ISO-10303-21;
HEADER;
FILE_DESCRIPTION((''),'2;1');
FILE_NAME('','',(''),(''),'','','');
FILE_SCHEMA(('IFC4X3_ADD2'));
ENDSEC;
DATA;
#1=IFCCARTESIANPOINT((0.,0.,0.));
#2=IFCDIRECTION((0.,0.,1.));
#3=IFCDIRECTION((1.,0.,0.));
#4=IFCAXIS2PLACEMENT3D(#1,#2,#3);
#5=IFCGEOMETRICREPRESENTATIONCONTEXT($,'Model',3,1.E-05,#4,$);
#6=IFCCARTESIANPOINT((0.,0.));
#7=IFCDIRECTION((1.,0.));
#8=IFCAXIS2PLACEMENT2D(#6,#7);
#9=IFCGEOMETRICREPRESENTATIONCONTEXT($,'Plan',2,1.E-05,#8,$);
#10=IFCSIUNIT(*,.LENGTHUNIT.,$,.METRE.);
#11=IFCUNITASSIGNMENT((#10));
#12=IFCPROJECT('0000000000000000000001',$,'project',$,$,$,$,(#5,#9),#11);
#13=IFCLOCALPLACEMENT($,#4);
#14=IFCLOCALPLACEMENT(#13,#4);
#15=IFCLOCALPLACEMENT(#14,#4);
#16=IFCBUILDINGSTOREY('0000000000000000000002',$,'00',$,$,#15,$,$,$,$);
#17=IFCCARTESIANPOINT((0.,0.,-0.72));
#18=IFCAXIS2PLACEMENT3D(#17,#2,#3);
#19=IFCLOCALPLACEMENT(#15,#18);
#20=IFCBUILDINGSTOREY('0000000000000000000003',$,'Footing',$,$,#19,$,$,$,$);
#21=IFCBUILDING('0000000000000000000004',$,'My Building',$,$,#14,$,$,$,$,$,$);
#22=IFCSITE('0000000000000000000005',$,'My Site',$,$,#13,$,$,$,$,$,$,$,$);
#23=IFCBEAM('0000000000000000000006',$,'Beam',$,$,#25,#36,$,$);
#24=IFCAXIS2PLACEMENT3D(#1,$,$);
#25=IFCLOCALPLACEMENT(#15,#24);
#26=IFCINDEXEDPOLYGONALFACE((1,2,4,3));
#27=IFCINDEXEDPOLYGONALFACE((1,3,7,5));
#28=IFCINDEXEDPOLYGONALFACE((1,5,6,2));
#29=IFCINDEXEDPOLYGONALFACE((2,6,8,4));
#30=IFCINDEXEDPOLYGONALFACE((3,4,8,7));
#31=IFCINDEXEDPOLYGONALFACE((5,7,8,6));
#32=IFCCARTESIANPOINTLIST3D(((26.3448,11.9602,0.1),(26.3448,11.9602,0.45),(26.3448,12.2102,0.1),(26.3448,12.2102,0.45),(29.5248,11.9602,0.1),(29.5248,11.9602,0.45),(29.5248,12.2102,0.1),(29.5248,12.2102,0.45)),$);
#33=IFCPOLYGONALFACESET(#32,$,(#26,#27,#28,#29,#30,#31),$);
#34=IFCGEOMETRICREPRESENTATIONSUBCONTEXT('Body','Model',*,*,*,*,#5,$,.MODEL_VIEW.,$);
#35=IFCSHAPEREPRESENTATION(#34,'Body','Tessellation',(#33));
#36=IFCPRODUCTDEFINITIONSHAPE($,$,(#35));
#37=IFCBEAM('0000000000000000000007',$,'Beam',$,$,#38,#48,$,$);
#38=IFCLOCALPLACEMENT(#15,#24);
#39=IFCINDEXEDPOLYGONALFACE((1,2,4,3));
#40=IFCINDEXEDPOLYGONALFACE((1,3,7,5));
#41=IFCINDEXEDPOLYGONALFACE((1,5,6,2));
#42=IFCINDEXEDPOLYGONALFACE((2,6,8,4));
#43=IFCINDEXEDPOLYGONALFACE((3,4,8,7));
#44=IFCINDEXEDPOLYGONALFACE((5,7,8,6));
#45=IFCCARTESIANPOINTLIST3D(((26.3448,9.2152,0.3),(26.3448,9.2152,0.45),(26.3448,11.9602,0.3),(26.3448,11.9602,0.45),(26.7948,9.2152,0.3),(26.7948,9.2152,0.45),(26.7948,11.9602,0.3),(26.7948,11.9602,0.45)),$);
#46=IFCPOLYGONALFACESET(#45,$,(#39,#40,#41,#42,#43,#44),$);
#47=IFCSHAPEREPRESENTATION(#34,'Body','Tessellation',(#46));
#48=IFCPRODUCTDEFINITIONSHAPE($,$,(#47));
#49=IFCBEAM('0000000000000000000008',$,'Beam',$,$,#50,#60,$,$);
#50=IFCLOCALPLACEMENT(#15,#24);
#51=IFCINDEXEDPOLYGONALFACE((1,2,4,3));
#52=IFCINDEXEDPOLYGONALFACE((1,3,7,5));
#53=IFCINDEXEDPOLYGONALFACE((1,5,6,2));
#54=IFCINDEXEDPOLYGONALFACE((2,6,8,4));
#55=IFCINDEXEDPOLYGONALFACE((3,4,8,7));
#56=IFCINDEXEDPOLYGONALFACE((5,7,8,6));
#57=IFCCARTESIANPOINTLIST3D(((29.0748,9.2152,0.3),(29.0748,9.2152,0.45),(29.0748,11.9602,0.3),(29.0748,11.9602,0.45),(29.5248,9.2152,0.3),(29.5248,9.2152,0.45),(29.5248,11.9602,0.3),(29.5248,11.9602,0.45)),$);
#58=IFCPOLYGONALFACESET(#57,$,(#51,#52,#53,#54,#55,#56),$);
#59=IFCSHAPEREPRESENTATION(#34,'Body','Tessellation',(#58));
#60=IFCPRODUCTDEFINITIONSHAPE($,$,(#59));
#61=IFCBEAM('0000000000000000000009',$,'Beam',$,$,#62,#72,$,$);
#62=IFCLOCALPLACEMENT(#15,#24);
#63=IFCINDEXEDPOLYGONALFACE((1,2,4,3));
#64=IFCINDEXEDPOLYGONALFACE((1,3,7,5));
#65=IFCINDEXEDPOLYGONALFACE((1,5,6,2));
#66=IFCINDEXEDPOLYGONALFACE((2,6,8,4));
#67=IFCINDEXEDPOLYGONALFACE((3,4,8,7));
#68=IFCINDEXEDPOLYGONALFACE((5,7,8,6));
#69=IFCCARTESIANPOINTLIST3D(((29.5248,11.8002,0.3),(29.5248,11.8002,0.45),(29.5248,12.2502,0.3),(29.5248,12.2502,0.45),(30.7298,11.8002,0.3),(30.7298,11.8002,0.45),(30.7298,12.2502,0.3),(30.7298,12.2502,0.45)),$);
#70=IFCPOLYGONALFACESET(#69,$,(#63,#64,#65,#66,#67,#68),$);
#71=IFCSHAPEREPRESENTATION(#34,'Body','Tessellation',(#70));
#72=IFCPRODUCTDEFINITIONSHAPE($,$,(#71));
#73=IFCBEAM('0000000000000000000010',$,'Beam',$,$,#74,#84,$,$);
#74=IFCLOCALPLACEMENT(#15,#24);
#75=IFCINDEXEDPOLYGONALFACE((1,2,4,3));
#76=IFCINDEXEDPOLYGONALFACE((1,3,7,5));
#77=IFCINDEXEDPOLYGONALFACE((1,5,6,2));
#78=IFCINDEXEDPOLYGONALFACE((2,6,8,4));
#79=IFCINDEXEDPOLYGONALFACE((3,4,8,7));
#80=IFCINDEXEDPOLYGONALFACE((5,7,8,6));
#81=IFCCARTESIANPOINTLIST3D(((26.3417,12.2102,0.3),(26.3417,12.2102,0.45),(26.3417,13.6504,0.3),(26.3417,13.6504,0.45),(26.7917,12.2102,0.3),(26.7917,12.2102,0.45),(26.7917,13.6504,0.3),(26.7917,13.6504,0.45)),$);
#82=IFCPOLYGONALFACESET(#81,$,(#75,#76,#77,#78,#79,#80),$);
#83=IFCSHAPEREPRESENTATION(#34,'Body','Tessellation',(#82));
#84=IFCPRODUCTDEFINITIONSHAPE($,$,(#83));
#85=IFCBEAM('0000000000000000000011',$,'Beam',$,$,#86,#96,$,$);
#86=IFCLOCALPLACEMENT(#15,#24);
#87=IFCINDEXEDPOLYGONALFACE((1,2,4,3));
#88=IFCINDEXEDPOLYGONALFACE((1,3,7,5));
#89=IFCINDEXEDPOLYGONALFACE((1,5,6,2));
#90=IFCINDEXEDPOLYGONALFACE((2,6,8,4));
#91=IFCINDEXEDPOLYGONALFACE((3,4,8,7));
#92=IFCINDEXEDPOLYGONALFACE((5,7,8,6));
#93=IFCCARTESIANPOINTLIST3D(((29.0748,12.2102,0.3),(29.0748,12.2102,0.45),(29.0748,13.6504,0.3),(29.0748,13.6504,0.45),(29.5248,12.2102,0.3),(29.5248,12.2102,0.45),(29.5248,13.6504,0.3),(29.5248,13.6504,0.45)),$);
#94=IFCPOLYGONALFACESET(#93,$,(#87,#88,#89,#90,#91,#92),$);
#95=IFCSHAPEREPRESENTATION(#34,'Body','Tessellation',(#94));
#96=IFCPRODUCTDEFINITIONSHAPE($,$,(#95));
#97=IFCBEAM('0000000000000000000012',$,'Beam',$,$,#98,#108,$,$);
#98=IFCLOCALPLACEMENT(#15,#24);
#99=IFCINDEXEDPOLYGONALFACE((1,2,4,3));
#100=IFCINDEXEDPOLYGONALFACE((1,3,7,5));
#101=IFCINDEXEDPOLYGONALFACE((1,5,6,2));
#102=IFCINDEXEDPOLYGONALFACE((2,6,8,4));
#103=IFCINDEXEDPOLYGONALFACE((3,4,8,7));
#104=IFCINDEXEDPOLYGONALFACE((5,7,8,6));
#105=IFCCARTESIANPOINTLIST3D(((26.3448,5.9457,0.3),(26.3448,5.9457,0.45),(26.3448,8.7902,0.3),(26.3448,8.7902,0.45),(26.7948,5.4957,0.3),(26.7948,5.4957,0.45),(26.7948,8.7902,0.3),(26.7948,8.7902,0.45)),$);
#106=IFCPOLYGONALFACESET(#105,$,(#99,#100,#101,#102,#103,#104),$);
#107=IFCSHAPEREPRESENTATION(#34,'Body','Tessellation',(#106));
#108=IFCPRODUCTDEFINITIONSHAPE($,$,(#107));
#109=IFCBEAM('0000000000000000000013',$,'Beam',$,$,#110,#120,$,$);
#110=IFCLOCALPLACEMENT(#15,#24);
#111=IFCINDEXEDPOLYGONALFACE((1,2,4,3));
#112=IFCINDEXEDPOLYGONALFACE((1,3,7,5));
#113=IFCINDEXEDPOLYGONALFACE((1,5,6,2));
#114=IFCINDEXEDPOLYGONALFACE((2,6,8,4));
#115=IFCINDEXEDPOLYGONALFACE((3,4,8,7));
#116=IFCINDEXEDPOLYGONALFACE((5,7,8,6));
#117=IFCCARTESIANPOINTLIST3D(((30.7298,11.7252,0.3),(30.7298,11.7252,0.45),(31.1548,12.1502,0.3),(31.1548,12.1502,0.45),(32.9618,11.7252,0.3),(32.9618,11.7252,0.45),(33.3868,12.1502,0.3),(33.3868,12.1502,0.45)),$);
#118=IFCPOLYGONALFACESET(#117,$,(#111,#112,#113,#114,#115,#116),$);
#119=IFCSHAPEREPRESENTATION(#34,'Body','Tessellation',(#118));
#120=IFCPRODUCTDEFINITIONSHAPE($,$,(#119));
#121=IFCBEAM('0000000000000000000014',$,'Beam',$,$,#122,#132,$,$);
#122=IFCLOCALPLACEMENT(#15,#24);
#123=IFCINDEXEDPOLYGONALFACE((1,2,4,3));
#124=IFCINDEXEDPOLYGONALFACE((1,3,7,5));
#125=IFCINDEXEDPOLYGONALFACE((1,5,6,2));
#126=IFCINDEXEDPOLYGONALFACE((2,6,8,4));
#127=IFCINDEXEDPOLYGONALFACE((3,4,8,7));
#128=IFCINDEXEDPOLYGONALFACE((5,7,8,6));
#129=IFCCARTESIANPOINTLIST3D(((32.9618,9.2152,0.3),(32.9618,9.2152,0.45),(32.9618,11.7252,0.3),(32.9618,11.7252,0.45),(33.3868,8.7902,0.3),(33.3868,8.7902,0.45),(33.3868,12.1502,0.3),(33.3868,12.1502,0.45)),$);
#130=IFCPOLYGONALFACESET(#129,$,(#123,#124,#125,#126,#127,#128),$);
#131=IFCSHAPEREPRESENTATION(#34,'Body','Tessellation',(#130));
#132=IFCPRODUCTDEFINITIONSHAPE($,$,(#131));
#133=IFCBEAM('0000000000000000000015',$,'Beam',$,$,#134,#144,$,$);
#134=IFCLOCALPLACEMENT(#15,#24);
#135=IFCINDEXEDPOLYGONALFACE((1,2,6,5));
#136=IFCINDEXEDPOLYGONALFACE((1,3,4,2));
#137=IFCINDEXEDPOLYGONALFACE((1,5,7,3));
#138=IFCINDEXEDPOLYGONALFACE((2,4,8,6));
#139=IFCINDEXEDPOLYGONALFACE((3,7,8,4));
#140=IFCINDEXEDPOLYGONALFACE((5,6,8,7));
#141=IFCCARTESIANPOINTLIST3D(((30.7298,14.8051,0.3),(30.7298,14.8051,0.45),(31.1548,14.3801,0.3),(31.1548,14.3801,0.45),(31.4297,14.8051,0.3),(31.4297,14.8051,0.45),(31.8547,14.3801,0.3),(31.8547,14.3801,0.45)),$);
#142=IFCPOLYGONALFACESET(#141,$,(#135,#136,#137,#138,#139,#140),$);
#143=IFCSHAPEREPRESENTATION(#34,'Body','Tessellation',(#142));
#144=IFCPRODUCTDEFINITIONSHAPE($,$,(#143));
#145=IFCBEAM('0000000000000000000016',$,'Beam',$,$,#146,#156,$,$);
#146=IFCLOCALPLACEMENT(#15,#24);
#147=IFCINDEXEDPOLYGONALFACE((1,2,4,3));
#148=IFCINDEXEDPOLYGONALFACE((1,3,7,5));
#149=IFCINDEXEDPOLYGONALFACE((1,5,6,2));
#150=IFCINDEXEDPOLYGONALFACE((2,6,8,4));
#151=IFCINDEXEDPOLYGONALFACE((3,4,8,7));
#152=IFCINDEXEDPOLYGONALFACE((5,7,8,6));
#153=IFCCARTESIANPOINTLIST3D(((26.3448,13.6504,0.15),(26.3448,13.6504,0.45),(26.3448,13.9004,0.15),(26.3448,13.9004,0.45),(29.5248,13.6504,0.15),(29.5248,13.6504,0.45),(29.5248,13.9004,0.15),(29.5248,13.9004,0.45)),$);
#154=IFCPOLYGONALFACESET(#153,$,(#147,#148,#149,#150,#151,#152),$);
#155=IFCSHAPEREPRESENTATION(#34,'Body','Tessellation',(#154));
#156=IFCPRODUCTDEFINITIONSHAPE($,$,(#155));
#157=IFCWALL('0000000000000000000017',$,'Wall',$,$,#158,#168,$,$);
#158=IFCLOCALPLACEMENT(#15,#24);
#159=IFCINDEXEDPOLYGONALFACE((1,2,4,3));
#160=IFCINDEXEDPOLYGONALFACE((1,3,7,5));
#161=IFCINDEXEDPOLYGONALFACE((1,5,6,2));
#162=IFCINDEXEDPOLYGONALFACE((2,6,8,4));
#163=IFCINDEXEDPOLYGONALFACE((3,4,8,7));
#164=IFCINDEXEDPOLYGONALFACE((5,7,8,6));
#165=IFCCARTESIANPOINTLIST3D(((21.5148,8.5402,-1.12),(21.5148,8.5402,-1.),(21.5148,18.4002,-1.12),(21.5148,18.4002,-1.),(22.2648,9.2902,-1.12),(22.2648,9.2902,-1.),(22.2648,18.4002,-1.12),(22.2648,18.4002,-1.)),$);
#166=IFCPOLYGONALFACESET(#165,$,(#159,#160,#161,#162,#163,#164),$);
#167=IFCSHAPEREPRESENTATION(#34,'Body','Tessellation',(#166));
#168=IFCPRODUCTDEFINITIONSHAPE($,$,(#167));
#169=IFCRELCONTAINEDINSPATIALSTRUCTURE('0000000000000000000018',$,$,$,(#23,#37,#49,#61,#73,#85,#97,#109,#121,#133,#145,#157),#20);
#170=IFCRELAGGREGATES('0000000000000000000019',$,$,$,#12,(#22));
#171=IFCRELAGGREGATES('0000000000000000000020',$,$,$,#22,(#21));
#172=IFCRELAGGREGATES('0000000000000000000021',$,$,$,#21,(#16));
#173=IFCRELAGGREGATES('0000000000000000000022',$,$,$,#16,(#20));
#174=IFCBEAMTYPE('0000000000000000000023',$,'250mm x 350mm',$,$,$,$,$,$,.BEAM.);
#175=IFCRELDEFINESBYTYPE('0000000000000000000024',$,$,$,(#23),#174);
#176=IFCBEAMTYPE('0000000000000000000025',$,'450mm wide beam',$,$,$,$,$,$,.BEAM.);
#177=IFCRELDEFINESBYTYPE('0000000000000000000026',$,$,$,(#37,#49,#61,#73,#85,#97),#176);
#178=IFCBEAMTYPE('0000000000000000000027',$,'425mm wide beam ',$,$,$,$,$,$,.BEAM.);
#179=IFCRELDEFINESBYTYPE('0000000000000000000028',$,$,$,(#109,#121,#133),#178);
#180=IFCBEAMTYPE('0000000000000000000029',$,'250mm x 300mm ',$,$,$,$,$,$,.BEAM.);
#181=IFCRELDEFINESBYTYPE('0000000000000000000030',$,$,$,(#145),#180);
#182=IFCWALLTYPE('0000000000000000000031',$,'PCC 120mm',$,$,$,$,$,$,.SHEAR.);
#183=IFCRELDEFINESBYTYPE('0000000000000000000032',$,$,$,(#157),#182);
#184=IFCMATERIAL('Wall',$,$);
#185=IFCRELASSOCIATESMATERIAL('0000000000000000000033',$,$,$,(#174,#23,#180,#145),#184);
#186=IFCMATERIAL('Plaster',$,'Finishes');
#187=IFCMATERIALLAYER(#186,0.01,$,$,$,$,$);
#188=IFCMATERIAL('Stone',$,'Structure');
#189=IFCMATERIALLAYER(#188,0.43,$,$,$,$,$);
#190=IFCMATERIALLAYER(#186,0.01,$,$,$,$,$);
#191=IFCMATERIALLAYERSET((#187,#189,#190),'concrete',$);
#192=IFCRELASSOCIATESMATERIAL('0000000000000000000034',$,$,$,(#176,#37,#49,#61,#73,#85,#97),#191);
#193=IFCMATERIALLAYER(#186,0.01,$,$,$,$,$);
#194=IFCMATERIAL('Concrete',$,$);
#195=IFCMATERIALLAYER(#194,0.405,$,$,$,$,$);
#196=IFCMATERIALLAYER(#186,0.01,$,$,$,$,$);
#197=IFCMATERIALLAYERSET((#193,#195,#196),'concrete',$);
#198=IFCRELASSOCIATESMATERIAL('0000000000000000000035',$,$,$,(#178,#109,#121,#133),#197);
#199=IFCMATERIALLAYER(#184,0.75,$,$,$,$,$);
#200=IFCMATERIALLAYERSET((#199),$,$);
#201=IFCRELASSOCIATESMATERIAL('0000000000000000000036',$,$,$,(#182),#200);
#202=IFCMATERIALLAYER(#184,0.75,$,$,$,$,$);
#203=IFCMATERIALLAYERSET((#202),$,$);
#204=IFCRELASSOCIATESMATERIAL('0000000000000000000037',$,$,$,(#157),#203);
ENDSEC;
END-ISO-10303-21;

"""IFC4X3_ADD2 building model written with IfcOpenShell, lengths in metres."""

from ifc_helpers import new_model, si_unit, frame, origin_with_axes, origin_2d_with_axis, place, context, subcontext, project, spatial, line, indexed_curve, rectangle, outline, extrude, material, layer, layer_set, layer_usage, material_profile, profile_set, profile_usage, type_object, element, save


model = new_model("IFC4X3_ADD2")

# Units and contexts
model_context = context("Model", 3, precision=1e-05, world=origin_with_axes())
plan_context = context("Plan", 2, precision=1e-05, world=origin_2d_with_axis())
body_context = subcontext(model_context, "Body", "Model", "MODEL_VIEW")
ifc_project = project(units=[si_unit("LENGTHUNIT", "METRE")], contexts=[model_context, plan_context])

# Site, building, storeys
site_placement = place(None, origin_with_axes())
site = spatial("IfcSite", under=ifc_project, at=site_placement, Name="My Site")
building_placement = place(site_placement, origin_with_axes())
building = spatial("IfcBuilding", under=site, at=building_placement, Name="My Building")
storey_1_placement = place(building_placement, origin_with_axes())
storey_1 = spatial("IfcBuildingStorey", under=building, at=storey_1_placement, Name="00")
storey_2_placement = place(storey_1_placement, frame((0.0, 0.0, -0.72), z_axis=(0.0, 0.0, 1.0), x_axis=(1.0, 0.0, 0.0)))
storey_2 = spatial("IfcBuildingStorey", under=storey_1, at=storey_2_placement, Name="Footing")

# Beams
ifc_material_1 = material(Name="Wall")
ifc_material_profile_1 = material_profile(ifc_material_1, rectangle(XDim=0.25, YDim=0.35))
ifc_profile_set_1 = profile_set([ifc_material_profile_1], Name="concrete")
ifc_profile_usage_1 = profile_usage(ifc_profile_set_1, cardinal=5)
beam_type_1 = type_object("IfcBeamType", Name="250mm x 350mm", PredefinedType="BEAM", material=ifc_profile_set_1)
beam_1_placement = place(storey_2_placement, frame((29.5248, 12.0852, 0.995), z_axis=(-1.0, -0.000001, 0.000001), x_axis=(0.000001, -1.0, 0.0)))
element("IfcBeam", 1, at=beam_1_placement, inside=storey_2, type_object=beam_type_1, material=ifc_profile_usage_1, Name="Beam", context=body_context, shape_type="SweptSolid", body=[
    extrude(rectangle(XDim=0.25, YDim=0.35), origin_with_axes(), (0.0, 0.0, 1.0), 3.18),
])
ifc_material_2 = material(Name="Plaster", Category="Finishes")
ifc_layer_1 = layer(ifc_material_2, 0.01)
ifc_material_3 = material(Name="Stone", Category="Structure")
ifc_layer_2 = layer(ifc_material_3, 0.43)
ifc_layer_3 = layer(ifc_material_2, 0.01)
ifc_layer_set_1 = layer_set([ifc_layer_1, ifc_layer_2, ifc_layer_3], Name="concrete")
ifc_layer_usage_1 = layer_usage(ifc_layer_set_1, "AXIS2", "NEGATIVE", 0.0)
beam_type_2 = type_object("IfcBeamType", Name="450mm wide beam", PredefinedType="BEAM", material=ifc_layer_set_1)
beam_2_placement = place(storey_2_placement, frame((26.7948, 11.9602, 1.02), z_axis=(0.0, 0.0, 1.0), x_axis=(0.0, -1.0, 0.0)))
element("IfcBeam", 2, at=beam_2_placement, inside=storey_2, type_object=beam_type_2, material=ifc_layer_usage_1, Name="Beam", context=body_context, shape_type="SweptSolid", body=[
    extrude(outline(indexed_curve([(0.0, -0.45), (0.0, 0.0), (2.745, 0.0), (2.745, -0.45)], segments=[line(1, 2, 3, 4, 1)])), origin_with_axes(), (0.0, 0.0, 1.0), 0.15),
])
ifc_layer_usage_2 = layer_usage(ifc_layer_set_1, "AXIS2", "NEGATIVE", 0.0)
beam_3_placement = place(storey_2_placement, frame((29.5248, 11.9602, 1.02), z_axis=(0.0, 0.0, 1.0), x_axis=(0.0, -1.0, 0.0)))
element("IfcBeam", 3, at=beam_3_placement, inside=storey_2, type_object=beam_type_2, material=ifc_layer_usage_2, Name="Beam", context=body_context, shape_type="SweptSolid", body=[
    extrude(outline(indexed_curve([(0.0, -0.45), (0.0, 0.0), (2.745, 0.0), (2.745, -0.45)], segments=[line(1, 2, 3, 4, 1)])), origin_with_axes(), (0.0, 0.0, 1.0), 0.15),
])
ifc_layer_usage_3 = layer_usage(ifc_layer_set_1, "AXIS2", "NEGATIVE", 0.0)
beam_4_placement = place(storey_2_placement, frame((29.5248, 12.2502, 1.02), z_axis=(0.0, 0.0, 1.0), x_axis=(1.0, 0.0, 0.0)))
element("IfcBeam", 4, at=beam_4_placement, inside=storey_2, type_object=beam_type_2, material=ifc_layer_usage_3, Name="Beam", context=body_context, shape_type="SweptSolid", body=[
    extrude(outline(indexed_curve([(0.0, -0.45), (0.0, 0.0), (1.205, 0.0), (1.205, -0.45)], segments=[line(1, 2, 3, 4, 1)])), origin_with_axes(), (0.0, 0.0, 1.0), 0.15),
])
ifc_layer_usage_4 = layer_usage(ifc_layer_set_1, "AXIS2", "NEGATIVE", 0.0)
beam_5_placement = place(storey_2_placement, frame((26.7917, 13.6504, 1.02), z_axis=(0.0, 0.0, 1.0), x_axis=(0.0, -1.0, 0.0)))
element("IfcBeam", 5, at=beam_5_placement, inside=storey_2, type_object=beam_type_2, material=ifc_layer_usage_4, Name="Beam", context=body_context, shape_type="SweptSolid", body=[
    extrude(outline(indexed_curve([(0.0, -0.45), (0.0, 0.0), (1.4402, 0.0), (1.4402, -0.45)], segments=[line(1, 2, 3, 4, 1)])), origin_with_axes(), (0.0, 0.0, 1.0), 0.15),
])
ifc_layer_usage_5 = layer_usage(ifc_layer_set_1, "AXIS2", "NEGATIVE", 0.0)
beam_6_placement = place(storey_2_placement, frame((29.5248, 13.6504, 1.02), z_axis=(0.0, 0.0, 1.0), x_axis=(0.0, -1.0, 0.0)))
element("IfcBeam", 6, at=beam_6_placement, inside=storey_2, type_object=beam_type_2, material=ifc_layer_usage_5, Name="Beam", context=body_context, shape_type="SweptSolid", body=[
    extrude(outline(indexed_curve([(0.0, -0.45), (0.0, 0.0), (1.4402, 0.0), (1.4402, -0.45)], segments=[line(1, 2, 3, 4, 1)])), origin_with_axes(), (0.0, 0.0, 1.0), 0.15),
])
ifc_layer_usage_6 = layer_usage(ifc_layer_set_1, "AXIS2", "POSITIVE", 0.0)
beam_7_placement = place(storey_2_placement, frame((26.3448, 8.7902, 1.02), z_axis=(0.0, 0.0, 1.0), x_axis=(0.0, -1.0, 0.0)))
element("IfcBeam", 7, at=beam_7_placement, inside=storey_2, type_object=beam_type_2, material=ifc_layer_usage_6, Name="Beam", context=body_context, shape_type="SweptSolid", body=[
    extrude(outline(indexed_curve([(0.0, 0.0), (0.0, 0.45), (3.2945, 0.45), (2.8445, 0.0)], segments=[line(1, 2, 3, 4, 1)])), origin_with_axes(), (0.0, 0.0, 1.0), 0.15),
])
ifc_layer_4 = layer(ifc_material_2, 0.01)
ifc_material_4 = material(Name="Concrete")
ifc_layer_5 = layer(ifc_material_4, 0.405)
ifc_layer_6 = layer(ifc_material_2, 0.01)
ifc_layer_set_2 = layer_set([ifc_layer_4, ifc_layer_5, ifc_layer_6], Name="concrete")
ifc_layer_usage_7 = layer_usage(ifc_layer_set_2, "AXIS2", "POSITIVE", 0.0)
beam_type_3 = type_object("IfcBeamType", Name="425mm wide beam ", PredefinedType="BEAM", material=ifc_layer_set_2)
beam_8_placement = place(storey_2_placement, frame((30.7298, 11.7252, 1.02), z_axis=(0.0, 0.0, 1.0), x_axis=(1.0, 0.0, 0.0)))
element("IfcBeam", 8, at=beam_8_placement, inside=storey_2, type_object=beam_type_3, material=ifc_layer_usage_7, Name="Beam", context=body_context, shape_type="SweptSolid", body=[
    extrude(outline(indexed_curve([(0.0, 0.0), (0.425, 0.425), (2.657, 0.425), (2.232, 0.0)], segments=[line(1, 2, 3, 4, 1)])), origin_with_axes(), (0.0, 0.0, 1.0), 0.15),
])
ifc_layer_usage_8 = layer_usage(ifc_layer_set_2, "AXIS2", "POSITIVE", 0.0)
beam_9_placement = place(storey_2_placement, frame((32.9618, 11.7252, 1.02), z_axis=(0.0, 0.0, 1.0), x_axis=(0.0, -1.0, 0.0)))
element("IfcBeam", 9, at=beam_9_placement, inside=storey_2, type_object=beam_type_3, material=ifc_layer_usage_8, Name="Beam", context=body_context, shape_type="SweptSolid", body=[
    extrude(outline(indexed_curve([(0.0, 0.0), (-0.425, 0.425), (2.935, 0.425), (2.51, 0.0)], segments=[line(1, 2, 3, 4, 1)])), origin_with_axes(), (0.0, 0.0, 1.0), 0.15),
])
ifc_layer_usage_9 = layer_usage(ifc_layer_set_2, "AXIS2", "POSITIVE", 0.0)
beam_10_placement = place(storey_2_placement, frame((30.7298, 14.3801, 1.02), z_axis=(0.0, 0.0, 1.0), x_axis=(1.0, 0.0, 0.0)))
element("IfcBeam", 10, at=beam_10_placement, inside=storey_2, type_object=beam_type_3, material=ifc_layer_usage_9, Name="Beam", context=body_context, shape_type="SweptSolid", body=[
    extrude(outline(indexed_curve([(0.425, 0.0), (0.0, 0.425), (0.7, 0.425), (1.125, 0.0)], segments=[line(1, 2, 3, 4, 1)])), origin_with_axes(), (0.0, 0.0, 1.0), 0.15),
])
ifc_material_profile_2 = material_profile(ifc_material_1, rectangle(XDim=0.25, YDim=0.3))
ifc_profile_set_2 = profile_set([ifc_material_profile_2], Name="concrete")
ifc_profile_usage_2 = profile_usage(ifc_profile_set_2)
beam_type_4 = type_object("IfcBeamType", Name="250mm x 300mm ", PredefinedType="BEAM", material=ifc_profile_set_2)
beam_11_placement = place(storey_2_placement, frame((29.5248, 13.7754, 1.02), z_axis=(-1.0, -0.000001, 0.000001), x_axis=(0.000001, -1.0, 0.0)))
element("IfcBeam", 11, at=beam_11_placement, inside=storey_2, type_object=beam_type_4, material=ifc_profile_usage_2, Name="Beam", context=body_context, shape_type="SweptSolid", body=[
    extrude(rectangle(XDim=0.25, YDim=0.3), origin_with_axes(), (0.0, 0.0, 1.0), 3.18),
])

# Wall
ifc_layer_7 = layer(ifc_material_1, 0.75)
ifc_layer_set_3 = layer_set([ifc_layer_7])
wall_type_1 = type_object("IfcWallType", Name="PCC 120mm", PredefinedType="SHEAR", material=ifc_layer_set_3)
ifc_layer_8 = layer(ifc_material_1, 0.75)
ifc_layer_set_4 = layer_set([ifc_layer_8])
ifc_layer_usage_10 = layer_usage(ifc_layer_set_4, "AXIS2", "POSITIVE", 0.0)
wall_1_placement = place(storey_2_placement, frame((22.2648, 8.5402, -0.4), z_axis=(0.0, 0.0, 1.0), x_axis=(0.0, 1.0, 0.0)))
element("IfcWall", 12, at=wall_1_placement, inside=storey_2, type_object=wall_type_1, material=ifc_layer_usage_10, Name="Wall", context=body_context, shape_type="SweptSolid", body=[
    extrude(outline(indexed_curve([(0.75, 0.0), (0.0, 0.75), (9.86, 0.75), (9.86, 0.0)], segments=[line(1, 2, 3, 4, 1)])), origin_with_axes(), (0.0, 0.0, 1.0), 0.12),
])

save(model, "model.ifc")
